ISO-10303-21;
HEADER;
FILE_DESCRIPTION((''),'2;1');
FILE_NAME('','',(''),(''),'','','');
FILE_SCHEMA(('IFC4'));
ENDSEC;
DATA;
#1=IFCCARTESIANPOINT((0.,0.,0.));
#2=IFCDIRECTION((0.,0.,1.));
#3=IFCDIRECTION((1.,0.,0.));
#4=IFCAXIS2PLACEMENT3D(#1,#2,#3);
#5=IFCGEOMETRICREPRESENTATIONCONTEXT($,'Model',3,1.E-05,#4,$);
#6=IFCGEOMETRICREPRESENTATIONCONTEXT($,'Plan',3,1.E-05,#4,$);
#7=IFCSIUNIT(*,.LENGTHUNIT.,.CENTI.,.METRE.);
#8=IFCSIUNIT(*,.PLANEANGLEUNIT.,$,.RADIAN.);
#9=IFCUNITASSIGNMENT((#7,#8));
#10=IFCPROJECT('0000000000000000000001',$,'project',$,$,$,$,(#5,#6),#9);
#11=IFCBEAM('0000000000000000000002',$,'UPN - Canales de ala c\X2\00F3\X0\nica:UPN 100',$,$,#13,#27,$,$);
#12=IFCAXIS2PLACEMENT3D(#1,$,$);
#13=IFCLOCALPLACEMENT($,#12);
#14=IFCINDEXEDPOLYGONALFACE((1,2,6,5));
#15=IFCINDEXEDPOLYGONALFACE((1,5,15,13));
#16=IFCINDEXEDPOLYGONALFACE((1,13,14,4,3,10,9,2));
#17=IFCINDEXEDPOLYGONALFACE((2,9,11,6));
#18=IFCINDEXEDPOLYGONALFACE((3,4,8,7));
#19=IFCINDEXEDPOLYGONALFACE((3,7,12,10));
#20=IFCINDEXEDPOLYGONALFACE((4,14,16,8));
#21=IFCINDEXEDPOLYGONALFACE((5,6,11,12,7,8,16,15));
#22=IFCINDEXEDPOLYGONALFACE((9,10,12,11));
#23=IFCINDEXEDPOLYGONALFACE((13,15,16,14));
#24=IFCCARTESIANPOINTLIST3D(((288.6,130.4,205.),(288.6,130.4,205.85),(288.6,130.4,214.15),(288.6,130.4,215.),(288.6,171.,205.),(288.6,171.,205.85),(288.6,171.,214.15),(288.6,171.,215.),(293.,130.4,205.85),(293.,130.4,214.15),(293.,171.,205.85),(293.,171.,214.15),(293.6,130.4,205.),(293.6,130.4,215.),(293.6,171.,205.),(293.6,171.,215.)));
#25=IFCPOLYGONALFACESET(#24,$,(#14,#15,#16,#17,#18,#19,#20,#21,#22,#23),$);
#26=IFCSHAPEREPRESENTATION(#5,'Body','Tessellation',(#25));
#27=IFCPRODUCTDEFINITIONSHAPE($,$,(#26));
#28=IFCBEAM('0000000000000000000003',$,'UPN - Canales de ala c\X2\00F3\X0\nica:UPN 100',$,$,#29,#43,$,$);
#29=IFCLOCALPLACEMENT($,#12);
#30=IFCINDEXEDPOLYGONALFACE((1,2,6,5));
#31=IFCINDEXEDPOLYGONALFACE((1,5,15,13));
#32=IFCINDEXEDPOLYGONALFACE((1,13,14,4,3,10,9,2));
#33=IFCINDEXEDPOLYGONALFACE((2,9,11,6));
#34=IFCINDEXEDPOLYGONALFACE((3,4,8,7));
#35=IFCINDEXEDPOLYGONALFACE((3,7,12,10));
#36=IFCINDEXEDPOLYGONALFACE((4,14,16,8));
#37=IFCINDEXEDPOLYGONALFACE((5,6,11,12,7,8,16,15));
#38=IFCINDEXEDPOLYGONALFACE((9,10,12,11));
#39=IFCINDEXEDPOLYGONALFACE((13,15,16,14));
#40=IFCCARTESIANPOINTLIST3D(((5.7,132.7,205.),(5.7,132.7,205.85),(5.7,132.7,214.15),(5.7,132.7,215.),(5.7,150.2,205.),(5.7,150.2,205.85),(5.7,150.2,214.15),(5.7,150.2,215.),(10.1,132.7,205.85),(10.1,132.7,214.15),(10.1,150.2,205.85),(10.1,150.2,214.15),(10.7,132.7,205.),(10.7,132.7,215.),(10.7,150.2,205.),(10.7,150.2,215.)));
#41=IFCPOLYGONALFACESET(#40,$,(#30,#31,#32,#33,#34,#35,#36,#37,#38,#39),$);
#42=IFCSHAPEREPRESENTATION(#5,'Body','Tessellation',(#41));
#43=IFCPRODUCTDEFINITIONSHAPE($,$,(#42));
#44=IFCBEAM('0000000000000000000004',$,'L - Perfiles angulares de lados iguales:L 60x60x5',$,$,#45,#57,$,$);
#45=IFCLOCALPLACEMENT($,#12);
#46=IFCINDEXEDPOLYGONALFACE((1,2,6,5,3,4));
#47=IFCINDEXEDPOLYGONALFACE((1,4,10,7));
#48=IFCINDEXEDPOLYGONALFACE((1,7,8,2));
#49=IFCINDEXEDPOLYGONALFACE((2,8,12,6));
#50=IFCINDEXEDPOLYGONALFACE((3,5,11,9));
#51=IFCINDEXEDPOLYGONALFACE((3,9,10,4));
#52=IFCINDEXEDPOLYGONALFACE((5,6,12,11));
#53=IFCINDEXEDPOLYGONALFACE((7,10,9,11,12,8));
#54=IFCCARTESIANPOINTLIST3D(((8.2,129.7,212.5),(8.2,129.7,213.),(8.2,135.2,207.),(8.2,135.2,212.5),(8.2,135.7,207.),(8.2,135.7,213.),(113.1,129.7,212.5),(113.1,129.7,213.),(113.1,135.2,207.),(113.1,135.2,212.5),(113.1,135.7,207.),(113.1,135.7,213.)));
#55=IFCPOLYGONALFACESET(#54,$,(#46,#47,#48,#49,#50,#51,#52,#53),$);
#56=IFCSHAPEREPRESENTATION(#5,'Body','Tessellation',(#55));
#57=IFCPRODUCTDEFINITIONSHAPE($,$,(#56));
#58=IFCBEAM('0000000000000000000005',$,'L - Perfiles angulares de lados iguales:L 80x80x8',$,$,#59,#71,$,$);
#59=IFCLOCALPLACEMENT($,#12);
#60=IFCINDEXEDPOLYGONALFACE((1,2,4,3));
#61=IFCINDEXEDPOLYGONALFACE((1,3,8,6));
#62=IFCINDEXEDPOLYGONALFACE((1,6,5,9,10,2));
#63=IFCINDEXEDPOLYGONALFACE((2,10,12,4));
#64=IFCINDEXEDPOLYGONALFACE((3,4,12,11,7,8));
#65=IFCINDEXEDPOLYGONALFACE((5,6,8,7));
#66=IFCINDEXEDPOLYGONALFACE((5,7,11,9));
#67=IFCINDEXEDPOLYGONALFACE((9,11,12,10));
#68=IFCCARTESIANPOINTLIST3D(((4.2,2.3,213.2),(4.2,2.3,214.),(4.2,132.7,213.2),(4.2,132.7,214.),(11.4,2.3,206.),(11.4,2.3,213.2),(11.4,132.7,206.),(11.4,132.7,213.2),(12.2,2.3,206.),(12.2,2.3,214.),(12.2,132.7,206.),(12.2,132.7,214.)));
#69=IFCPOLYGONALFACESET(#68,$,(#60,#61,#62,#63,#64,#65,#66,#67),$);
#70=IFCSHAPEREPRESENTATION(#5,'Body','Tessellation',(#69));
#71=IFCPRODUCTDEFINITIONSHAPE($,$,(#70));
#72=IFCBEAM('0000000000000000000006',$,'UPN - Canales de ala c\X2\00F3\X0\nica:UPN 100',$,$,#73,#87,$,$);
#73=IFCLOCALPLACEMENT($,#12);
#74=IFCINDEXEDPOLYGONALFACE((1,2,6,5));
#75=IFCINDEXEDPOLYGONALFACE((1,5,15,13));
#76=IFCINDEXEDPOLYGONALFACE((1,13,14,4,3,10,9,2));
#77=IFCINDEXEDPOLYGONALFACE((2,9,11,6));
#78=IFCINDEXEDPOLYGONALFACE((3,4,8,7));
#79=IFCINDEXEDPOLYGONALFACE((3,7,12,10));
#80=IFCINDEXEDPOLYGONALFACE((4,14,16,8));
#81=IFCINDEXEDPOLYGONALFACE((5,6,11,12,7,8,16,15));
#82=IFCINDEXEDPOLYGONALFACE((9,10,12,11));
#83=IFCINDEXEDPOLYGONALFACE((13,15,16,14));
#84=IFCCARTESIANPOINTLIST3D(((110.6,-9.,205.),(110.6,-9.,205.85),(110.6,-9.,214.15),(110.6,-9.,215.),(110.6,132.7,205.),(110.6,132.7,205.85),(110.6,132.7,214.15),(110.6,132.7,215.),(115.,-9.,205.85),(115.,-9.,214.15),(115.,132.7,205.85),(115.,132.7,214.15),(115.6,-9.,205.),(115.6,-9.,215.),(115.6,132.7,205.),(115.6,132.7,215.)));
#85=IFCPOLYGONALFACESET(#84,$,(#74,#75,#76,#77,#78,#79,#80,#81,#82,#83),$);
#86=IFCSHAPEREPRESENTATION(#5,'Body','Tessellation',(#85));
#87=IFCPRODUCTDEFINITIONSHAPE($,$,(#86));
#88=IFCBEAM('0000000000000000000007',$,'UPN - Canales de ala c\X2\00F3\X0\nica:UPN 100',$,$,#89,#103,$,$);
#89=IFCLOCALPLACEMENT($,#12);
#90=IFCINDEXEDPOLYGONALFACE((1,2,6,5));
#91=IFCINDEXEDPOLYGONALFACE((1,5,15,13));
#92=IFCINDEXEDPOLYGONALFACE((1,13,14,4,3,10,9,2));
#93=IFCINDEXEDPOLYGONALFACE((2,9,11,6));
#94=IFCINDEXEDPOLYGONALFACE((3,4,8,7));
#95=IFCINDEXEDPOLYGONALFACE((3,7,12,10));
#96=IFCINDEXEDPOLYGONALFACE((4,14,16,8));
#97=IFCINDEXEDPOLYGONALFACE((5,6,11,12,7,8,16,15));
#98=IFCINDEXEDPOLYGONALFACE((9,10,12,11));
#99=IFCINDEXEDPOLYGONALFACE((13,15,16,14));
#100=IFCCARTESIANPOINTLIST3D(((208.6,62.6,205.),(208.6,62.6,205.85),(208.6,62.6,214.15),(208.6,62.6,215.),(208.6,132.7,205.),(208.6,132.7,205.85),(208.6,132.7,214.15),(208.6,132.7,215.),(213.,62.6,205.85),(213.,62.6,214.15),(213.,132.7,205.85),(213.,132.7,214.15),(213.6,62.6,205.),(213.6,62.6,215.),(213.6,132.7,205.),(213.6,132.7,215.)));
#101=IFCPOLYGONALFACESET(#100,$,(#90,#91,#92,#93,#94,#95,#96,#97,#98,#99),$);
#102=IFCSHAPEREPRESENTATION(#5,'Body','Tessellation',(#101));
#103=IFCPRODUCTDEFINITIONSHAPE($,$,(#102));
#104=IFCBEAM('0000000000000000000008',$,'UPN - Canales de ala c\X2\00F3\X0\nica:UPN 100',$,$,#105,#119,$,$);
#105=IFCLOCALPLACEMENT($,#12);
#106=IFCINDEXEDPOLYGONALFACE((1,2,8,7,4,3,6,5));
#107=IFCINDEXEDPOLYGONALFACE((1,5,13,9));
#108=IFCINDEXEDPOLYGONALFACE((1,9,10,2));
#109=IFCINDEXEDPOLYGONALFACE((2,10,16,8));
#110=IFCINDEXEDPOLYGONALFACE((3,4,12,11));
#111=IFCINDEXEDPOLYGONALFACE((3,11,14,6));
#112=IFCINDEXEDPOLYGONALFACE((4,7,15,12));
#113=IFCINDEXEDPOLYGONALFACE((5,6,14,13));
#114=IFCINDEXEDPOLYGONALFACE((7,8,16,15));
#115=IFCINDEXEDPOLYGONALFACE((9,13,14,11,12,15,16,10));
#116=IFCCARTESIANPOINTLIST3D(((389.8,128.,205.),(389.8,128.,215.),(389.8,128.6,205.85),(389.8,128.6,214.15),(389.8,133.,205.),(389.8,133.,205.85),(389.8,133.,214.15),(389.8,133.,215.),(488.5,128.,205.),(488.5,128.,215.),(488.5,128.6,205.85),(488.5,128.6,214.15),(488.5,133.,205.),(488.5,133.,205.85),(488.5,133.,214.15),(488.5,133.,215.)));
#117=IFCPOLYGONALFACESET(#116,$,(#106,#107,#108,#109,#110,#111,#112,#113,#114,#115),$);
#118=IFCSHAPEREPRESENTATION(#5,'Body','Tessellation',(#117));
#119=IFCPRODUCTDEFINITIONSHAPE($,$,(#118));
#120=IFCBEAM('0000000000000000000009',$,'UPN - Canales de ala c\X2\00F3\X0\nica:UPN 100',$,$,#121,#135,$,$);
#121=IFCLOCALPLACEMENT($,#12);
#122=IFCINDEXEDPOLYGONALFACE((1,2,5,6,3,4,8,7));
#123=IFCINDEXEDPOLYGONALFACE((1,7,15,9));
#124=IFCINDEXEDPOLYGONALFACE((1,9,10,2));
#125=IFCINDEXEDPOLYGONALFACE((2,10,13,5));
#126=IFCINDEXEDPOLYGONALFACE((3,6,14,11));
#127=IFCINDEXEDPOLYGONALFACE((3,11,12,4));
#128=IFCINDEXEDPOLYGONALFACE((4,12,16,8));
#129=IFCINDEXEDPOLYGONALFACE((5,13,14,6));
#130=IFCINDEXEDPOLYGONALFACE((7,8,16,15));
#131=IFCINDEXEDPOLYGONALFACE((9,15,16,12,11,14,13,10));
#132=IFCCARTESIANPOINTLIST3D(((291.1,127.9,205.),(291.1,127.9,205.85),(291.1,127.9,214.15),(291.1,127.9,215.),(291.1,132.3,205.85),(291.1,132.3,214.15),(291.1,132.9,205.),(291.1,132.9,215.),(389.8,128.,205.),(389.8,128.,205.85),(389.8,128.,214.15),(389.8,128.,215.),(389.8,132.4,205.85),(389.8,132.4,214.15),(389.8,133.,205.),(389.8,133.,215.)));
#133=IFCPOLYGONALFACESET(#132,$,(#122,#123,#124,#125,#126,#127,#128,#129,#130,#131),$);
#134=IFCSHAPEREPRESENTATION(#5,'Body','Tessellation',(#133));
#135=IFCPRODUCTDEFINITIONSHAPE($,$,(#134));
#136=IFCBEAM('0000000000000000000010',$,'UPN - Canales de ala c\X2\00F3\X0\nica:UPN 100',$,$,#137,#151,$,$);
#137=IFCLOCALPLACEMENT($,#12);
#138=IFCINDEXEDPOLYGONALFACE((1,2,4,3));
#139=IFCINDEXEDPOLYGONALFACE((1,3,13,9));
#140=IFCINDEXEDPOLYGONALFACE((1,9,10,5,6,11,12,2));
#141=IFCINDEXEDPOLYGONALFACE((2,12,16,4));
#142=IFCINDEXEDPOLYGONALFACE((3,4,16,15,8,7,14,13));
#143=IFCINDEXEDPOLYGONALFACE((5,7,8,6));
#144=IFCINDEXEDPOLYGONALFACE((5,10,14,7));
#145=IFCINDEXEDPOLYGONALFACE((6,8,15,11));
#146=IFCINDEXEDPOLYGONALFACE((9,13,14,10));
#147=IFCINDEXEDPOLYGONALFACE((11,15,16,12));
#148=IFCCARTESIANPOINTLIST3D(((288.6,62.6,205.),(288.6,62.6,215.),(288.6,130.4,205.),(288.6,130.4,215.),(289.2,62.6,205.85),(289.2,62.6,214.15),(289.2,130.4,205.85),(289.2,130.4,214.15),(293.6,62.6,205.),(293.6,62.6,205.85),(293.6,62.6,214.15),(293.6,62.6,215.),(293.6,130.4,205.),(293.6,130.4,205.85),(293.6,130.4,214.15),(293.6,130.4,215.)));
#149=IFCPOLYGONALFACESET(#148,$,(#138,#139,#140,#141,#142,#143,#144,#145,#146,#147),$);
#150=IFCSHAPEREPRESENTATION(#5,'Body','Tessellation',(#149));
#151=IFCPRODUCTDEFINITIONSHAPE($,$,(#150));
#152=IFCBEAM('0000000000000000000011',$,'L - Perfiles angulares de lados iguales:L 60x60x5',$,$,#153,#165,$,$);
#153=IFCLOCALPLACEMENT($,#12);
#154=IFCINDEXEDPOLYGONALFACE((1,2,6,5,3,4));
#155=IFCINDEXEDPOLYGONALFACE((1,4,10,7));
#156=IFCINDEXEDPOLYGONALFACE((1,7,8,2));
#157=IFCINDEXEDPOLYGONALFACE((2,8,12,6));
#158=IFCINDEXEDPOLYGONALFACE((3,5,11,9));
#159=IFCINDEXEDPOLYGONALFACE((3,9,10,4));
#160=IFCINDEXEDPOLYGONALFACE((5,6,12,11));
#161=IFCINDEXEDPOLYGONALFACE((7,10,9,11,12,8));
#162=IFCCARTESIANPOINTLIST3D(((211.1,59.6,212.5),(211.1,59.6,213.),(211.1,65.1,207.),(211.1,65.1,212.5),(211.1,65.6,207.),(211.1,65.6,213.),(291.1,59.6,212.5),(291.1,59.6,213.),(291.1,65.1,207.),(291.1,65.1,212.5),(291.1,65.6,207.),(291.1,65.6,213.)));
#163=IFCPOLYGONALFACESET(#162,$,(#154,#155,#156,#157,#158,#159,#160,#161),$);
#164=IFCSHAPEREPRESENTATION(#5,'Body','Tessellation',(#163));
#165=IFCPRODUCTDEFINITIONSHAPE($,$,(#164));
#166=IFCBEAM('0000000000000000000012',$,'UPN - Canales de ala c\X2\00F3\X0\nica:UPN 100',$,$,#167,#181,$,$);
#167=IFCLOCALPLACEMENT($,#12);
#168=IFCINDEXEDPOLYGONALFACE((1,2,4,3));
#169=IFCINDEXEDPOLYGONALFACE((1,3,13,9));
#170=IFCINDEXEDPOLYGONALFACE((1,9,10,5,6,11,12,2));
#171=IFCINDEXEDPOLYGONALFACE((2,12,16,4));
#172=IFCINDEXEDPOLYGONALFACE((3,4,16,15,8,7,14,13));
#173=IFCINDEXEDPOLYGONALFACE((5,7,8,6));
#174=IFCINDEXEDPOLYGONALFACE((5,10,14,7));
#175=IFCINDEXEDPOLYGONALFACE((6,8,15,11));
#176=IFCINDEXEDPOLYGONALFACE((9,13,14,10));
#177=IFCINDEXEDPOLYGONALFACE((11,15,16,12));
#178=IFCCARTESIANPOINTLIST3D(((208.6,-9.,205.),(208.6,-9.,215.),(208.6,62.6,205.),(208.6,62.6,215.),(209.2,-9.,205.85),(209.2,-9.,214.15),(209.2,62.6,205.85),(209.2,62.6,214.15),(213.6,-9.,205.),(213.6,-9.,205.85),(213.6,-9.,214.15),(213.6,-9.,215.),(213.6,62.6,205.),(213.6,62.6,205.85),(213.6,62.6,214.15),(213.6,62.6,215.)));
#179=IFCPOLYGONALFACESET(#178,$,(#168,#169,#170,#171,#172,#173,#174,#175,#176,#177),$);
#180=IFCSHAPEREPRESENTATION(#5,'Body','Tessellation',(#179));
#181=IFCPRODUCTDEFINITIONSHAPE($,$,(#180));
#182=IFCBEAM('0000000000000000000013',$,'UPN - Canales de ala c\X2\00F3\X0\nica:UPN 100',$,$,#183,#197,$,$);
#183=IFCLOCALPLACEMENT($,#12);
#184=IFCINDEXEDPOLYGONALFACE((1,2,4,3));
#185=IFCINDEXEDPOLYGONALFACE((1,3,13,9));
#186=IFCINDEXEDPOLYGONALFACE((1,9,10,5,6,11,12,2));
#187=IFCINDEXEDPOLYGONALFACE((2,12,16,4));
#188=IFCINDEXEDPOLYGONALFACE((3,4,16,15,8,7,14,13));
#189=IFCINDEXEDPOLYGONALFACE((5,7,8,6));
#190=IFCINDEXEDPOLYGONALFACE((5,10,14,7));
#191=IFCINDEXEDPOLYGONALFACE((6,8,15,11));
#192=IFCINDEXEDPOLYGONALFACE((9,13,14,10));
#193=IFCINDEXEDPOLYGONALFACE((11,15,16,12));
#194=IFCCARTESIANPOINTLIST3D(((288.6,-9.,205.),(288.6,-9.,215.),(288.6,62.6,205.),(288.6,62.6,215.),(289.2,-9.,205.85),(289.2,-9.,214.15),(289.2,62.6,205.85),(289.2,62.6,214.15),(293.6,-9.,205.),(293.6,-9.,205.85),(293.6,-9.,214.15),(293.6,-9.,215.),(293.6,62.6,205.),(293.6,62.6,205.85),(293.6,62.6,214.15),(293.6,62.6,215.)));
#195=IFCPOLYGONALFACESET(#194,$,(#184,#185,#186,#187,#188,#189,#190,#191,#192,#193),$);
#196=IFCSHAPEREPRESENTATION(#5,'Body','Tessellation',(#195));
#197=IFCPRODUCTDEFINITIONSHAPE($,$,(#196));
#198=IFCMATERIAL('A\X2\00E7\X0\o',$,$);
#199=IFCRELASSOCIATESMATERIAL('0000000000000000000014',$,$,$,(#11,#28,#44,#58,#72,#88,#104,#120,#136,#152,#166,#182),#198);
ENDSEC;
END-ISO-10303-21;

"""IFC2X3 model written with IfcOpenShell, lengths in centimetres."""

from ifc_helpers import new_model, si_unit, frame, frame_2d, origin_with_axes, origin_2d_with_axis, place, context, project, polyline, u_section, outline, extrude, material, element, save


model = new_model("IFC2X3")

# Units and contexts
model_context = context("Model", 3, precision=1e-05, world=origin_with_axes())
plan_context = context("Plan", 3, precision=1e-05, world=origin_with_axes())
ifc_project = project(units=[si_unit("LENGTHUNIT", "METRE", prefix="CENTI"), si_unit("PLANEANGLEUNIT", "RADIAN")], contexts=[model_context, plan_context])

# Shared definitions
ifc_material = material(Name="Aço")

# Beams
beam_1_placement = place(None, frame((291.1, 130.4, 210.0), z_axis=(0.0, 1.0, 0.0), x_axis=(-1.0, 0.0, 0.0)))
element("IfcBeam", 1, at=beam_1_placement, material=ifc_material, Name="UPN - Canales de ala cónica:UPN 100", context=model_context, shape_type="SweptSolid", body=[
    extrude(u_section(Depth=10.0, FlangeWidth=5.0, WebThickness=0.6, FlangeThickness=0.85, FilletRadius=0.0, EdgeRadius=0.0, FlangeSlope=0.0, CentreOfGravityInX=0.0, at=origin_2d_with_axis()), origin_with_axes(), (0.0, 0.0, 1.0), 40.6),
])
beam_2_placement = place(None, frame((8.2, 132.7, 210.0), z_axis=(0.0, 1.0, 0.0), x_axis=(-1.0, 0.0, 0.0)))
element("IfcBeam", 2, at=beam_2_placement, material=ifc_material, Name="UPN - Canales de ala cónica:UPN 100", context=model_context, shape_type="SweptSolid", body=[
    extrude(u_section(Depth=10.0, FlangeWidth=5.0, WebThickness=0.6, FlangeThickness=0.85, FilletRadius=0.0, EdgeRadius=0.0, FlangeSlope=0.0, CentreOfGravityInX=0.0, at=origin_2d_with_axis()), origin_with_axes(), (0.0, 0.0, 1.0), 17.5),
])
beam_3_placement = place(None, frame((113.1, 132.7, 210.0), z_axis=(-1.0, 0.0, 0.0), x_axis=(0.0, 0.0, 1.0)))
element("IfcBeam", 3, at=beam_3_placement, material=ifc_material, Name="L - Perfiles angulares de lados iguales:L 60x60x5", context=model_context, shape_type="SweptSolid", body=[
    extrude(outline(polyline([(3.0, -3.0), (3.0, 3.0), (-3.0, 3.0), (-3.0, 2.5), (2.5, 2.5), (2.5, -3.0), (3.0, -3.0)])), origin_with_axes(), (0.0, 0.0, 1.0), 104.9),
])
beam_4_placement = place(None, frame((8.2, 2.3, 210.0), z_axis=(0.0, 1.0, 0.0), x_axis=(0.0, 0.0, 1.0)))
element("IfcBeam", 4, at=beam_4_placement, material=ifc_material, Name="L - Perfiles angulares de lados iguales:L 80x80x8", context=model_context, shape_type="SweptSolid", body=[
    extrude(outline(polyline([(4.0, -4.0), (4.0, 4.0), (-4.0, 4.0), (-4.0, 3.2), (3.2, 3.2), (3.2, -4.0), (4.0, -4.0)])), origin_with_axes(), (0.0, 0.0, 1.0), 130.4),
])
beam_5_placement = place(None, frame((113.1, -9.0, 210.0), z_axis=(0.0, 1.0, 0.0), x_axis=(-1.0, 0.0, 0.0)))
element("IfcBeam", 5, at=beam_5_placement, material=ifc_material, Name="UPN - Canales de ala cónica:UPN 100", context=model_context, shape_type="SweptSolid", body=[
    extrude(u_section(Depth=10.0, FlangeWidth=5.0, WebThickness=0.6, FlangeThickness=0.85, FilletRadius=0.0, EdgeRadius=0.0, FlangeSlope=0.0, CentreOfGravityInX=0.0, at=origin_2d_with_axis()), origin_with_axes(), (0.0, 0.0, 1.0), 141.7),
])
beam_6_placement = place(None, frame((211.1, 62.6, 210.0), z_axis=(0.0, 1.0, 0.0), x_axis=(-1.0, 0.0, 0.0)))
element("IfcBeam", 6, at=beam_6_placement, material=ifc_material, Name="UPN - Canales de ala cónica:UPN 100", context=model_context, shape_type="SweptSolid", body=[
    extrude(u_section(Depth=10.0, FlangeWidth=5.0, WebThickness=0.6, FlangeThickness=0.85, FilletRadius=0.0, EdgeRadius=0.0, FlangeSlope=0.0, CentreOfGravityInX=0.0, at=origin_2d_with_axis()), origin_with_axes(), (0.0, 0.0, 1.0), 70.1),
])
beam_7_placement = place(None, frame((488.5, 130.5, 210.0), z_axis=(-1.0, 0.0, 0.0), x_axis=(0.0, 1.0, 0.0)))
element("IfcBeam", 7, at=beam_7_placement, material=ifc_material, Name="UPN - Canales de ala cónica:UPN 100", context=model_context, shape_type="SweptSolid", body=[
    extrude(u_section(Depth=10.0, FlangeWidth=5.0, WebThickness=0.6, FlangeThickness=0.85, FilletRadius=0.0, EdgeRadius=0.0, FlangeSlope=0.0, CentreOfGravityInX=0.0, at=origin_2d_with_axis()), origin_with_axes(), (0.0, 0.0, 1.0), 98.7),
])
beam_8_placement = place(None, frame((291.1, 130.4, 210.0), z_axis=(0.999999, 0.001013, 0.0), x_axis=(0.001013, -0.999999, 0.0)))
element("IfcBeam", 8, at=beam_8_placement, material=ifc_material, Name="UPN - Canales de ala cónica:UPN 100", context=model_context, shape_type="SweptSolid", body=[
    extrude(u_section(Depth=10.0, FlangeWidth=5.0, WebThickness=0.6, FlangeThickness=0.85, FilletRadius=0.0, EdgeRadius=0.0, FlangeSlope=0.0, CentreOfGravityInX=0.0, at=frame_2d((0.0, 0.0), x_axis=(1.0, 0.0))), origin_with_axes(), (0.0, 0.0, 1.0), 98.7),
])
beam_9_placement = place(None, frame((291.1, 62.6, 210.0), z_axis=(0.0, 1.0, 0.0), x_axis=(1.0, 0.0, 0.0)))
element("IfcBeam", 9, at=beam_9_placement, material=ifc_material, Name="UPN - Canales de ala cónica:UPN 100", context=model_context, shape_type="SweptSolid", body=[
    extrude(u_section(Depth=10.0, FlangeWidth=5.0, WebThickness=0.6, FlangeThickness=0.85, FilletRadius=0.0, EdgeRadius=0.0, FlangeSlope=0.0, CentreOfGravityInX=0.0, at=origin_2d_with_axis()), origin_with_axes(), (0.0, 0.0, 1.0), 67.8),
])
beam_10_placement = place(None, frame((291.1, 62.6, 210.0), z_axis=(-1.0, 0.0, 0.0), x_axis=(0.0, 0.0, 1.0)))
element("IfcBeam", 10, at=beam_10_placement, material=ifc_material, Name="L - Perfiles angulares de lados iguales:L 60x60x5", context=model_context, shape_type="SweptSolid", body=[
    extrude(outline(polyline([(3.0, -3.0), (3.0, 3.0), (-3.0, 3.0), (-3.0, 2.5), (2.5, 2.5), (2.5, -3.0), (3.0, -3.0)])), origin_with_axes(), (0.0, 0.0, 1.0), 80.0),
])
for number, where, z_axis, x_axis, name in (
    (11, (211.1, -9.0, 210.0), (0.0, 1.0, 0.0), (1.0, 0.0, 0.0), "UPN - Canales de ala cónica:UPN 100"),
    (12, (291.1, -9.0, 210.0), (0.0, 1.0, 0.0), (1.0, 0.0, 0.0), "UPN - Canales de ala cónica:UPN 100"),
):
    element("IfcBeam", number, at=place(None, frame(where, z_axis=z_axis, x_axis=x_axis)), material=ifc_material, Name=name, context=model_context, shape_type="SweptSolid", body=[
        extrude(u_section(Depth=10.0, FlangeWidth=5.0, WebThickness=0.6, FlangeThickness=0.85, FilletRadius=0.0, EdgeRadius=0.0, FlangeSlope=0.0, CentreOfGravityInX=0.0, at=origin_2d_with_axis()), origin_with_axes(), (0.0, 0.0, 1.0), 71.6),
    ])

save(model, "model.ifc")
